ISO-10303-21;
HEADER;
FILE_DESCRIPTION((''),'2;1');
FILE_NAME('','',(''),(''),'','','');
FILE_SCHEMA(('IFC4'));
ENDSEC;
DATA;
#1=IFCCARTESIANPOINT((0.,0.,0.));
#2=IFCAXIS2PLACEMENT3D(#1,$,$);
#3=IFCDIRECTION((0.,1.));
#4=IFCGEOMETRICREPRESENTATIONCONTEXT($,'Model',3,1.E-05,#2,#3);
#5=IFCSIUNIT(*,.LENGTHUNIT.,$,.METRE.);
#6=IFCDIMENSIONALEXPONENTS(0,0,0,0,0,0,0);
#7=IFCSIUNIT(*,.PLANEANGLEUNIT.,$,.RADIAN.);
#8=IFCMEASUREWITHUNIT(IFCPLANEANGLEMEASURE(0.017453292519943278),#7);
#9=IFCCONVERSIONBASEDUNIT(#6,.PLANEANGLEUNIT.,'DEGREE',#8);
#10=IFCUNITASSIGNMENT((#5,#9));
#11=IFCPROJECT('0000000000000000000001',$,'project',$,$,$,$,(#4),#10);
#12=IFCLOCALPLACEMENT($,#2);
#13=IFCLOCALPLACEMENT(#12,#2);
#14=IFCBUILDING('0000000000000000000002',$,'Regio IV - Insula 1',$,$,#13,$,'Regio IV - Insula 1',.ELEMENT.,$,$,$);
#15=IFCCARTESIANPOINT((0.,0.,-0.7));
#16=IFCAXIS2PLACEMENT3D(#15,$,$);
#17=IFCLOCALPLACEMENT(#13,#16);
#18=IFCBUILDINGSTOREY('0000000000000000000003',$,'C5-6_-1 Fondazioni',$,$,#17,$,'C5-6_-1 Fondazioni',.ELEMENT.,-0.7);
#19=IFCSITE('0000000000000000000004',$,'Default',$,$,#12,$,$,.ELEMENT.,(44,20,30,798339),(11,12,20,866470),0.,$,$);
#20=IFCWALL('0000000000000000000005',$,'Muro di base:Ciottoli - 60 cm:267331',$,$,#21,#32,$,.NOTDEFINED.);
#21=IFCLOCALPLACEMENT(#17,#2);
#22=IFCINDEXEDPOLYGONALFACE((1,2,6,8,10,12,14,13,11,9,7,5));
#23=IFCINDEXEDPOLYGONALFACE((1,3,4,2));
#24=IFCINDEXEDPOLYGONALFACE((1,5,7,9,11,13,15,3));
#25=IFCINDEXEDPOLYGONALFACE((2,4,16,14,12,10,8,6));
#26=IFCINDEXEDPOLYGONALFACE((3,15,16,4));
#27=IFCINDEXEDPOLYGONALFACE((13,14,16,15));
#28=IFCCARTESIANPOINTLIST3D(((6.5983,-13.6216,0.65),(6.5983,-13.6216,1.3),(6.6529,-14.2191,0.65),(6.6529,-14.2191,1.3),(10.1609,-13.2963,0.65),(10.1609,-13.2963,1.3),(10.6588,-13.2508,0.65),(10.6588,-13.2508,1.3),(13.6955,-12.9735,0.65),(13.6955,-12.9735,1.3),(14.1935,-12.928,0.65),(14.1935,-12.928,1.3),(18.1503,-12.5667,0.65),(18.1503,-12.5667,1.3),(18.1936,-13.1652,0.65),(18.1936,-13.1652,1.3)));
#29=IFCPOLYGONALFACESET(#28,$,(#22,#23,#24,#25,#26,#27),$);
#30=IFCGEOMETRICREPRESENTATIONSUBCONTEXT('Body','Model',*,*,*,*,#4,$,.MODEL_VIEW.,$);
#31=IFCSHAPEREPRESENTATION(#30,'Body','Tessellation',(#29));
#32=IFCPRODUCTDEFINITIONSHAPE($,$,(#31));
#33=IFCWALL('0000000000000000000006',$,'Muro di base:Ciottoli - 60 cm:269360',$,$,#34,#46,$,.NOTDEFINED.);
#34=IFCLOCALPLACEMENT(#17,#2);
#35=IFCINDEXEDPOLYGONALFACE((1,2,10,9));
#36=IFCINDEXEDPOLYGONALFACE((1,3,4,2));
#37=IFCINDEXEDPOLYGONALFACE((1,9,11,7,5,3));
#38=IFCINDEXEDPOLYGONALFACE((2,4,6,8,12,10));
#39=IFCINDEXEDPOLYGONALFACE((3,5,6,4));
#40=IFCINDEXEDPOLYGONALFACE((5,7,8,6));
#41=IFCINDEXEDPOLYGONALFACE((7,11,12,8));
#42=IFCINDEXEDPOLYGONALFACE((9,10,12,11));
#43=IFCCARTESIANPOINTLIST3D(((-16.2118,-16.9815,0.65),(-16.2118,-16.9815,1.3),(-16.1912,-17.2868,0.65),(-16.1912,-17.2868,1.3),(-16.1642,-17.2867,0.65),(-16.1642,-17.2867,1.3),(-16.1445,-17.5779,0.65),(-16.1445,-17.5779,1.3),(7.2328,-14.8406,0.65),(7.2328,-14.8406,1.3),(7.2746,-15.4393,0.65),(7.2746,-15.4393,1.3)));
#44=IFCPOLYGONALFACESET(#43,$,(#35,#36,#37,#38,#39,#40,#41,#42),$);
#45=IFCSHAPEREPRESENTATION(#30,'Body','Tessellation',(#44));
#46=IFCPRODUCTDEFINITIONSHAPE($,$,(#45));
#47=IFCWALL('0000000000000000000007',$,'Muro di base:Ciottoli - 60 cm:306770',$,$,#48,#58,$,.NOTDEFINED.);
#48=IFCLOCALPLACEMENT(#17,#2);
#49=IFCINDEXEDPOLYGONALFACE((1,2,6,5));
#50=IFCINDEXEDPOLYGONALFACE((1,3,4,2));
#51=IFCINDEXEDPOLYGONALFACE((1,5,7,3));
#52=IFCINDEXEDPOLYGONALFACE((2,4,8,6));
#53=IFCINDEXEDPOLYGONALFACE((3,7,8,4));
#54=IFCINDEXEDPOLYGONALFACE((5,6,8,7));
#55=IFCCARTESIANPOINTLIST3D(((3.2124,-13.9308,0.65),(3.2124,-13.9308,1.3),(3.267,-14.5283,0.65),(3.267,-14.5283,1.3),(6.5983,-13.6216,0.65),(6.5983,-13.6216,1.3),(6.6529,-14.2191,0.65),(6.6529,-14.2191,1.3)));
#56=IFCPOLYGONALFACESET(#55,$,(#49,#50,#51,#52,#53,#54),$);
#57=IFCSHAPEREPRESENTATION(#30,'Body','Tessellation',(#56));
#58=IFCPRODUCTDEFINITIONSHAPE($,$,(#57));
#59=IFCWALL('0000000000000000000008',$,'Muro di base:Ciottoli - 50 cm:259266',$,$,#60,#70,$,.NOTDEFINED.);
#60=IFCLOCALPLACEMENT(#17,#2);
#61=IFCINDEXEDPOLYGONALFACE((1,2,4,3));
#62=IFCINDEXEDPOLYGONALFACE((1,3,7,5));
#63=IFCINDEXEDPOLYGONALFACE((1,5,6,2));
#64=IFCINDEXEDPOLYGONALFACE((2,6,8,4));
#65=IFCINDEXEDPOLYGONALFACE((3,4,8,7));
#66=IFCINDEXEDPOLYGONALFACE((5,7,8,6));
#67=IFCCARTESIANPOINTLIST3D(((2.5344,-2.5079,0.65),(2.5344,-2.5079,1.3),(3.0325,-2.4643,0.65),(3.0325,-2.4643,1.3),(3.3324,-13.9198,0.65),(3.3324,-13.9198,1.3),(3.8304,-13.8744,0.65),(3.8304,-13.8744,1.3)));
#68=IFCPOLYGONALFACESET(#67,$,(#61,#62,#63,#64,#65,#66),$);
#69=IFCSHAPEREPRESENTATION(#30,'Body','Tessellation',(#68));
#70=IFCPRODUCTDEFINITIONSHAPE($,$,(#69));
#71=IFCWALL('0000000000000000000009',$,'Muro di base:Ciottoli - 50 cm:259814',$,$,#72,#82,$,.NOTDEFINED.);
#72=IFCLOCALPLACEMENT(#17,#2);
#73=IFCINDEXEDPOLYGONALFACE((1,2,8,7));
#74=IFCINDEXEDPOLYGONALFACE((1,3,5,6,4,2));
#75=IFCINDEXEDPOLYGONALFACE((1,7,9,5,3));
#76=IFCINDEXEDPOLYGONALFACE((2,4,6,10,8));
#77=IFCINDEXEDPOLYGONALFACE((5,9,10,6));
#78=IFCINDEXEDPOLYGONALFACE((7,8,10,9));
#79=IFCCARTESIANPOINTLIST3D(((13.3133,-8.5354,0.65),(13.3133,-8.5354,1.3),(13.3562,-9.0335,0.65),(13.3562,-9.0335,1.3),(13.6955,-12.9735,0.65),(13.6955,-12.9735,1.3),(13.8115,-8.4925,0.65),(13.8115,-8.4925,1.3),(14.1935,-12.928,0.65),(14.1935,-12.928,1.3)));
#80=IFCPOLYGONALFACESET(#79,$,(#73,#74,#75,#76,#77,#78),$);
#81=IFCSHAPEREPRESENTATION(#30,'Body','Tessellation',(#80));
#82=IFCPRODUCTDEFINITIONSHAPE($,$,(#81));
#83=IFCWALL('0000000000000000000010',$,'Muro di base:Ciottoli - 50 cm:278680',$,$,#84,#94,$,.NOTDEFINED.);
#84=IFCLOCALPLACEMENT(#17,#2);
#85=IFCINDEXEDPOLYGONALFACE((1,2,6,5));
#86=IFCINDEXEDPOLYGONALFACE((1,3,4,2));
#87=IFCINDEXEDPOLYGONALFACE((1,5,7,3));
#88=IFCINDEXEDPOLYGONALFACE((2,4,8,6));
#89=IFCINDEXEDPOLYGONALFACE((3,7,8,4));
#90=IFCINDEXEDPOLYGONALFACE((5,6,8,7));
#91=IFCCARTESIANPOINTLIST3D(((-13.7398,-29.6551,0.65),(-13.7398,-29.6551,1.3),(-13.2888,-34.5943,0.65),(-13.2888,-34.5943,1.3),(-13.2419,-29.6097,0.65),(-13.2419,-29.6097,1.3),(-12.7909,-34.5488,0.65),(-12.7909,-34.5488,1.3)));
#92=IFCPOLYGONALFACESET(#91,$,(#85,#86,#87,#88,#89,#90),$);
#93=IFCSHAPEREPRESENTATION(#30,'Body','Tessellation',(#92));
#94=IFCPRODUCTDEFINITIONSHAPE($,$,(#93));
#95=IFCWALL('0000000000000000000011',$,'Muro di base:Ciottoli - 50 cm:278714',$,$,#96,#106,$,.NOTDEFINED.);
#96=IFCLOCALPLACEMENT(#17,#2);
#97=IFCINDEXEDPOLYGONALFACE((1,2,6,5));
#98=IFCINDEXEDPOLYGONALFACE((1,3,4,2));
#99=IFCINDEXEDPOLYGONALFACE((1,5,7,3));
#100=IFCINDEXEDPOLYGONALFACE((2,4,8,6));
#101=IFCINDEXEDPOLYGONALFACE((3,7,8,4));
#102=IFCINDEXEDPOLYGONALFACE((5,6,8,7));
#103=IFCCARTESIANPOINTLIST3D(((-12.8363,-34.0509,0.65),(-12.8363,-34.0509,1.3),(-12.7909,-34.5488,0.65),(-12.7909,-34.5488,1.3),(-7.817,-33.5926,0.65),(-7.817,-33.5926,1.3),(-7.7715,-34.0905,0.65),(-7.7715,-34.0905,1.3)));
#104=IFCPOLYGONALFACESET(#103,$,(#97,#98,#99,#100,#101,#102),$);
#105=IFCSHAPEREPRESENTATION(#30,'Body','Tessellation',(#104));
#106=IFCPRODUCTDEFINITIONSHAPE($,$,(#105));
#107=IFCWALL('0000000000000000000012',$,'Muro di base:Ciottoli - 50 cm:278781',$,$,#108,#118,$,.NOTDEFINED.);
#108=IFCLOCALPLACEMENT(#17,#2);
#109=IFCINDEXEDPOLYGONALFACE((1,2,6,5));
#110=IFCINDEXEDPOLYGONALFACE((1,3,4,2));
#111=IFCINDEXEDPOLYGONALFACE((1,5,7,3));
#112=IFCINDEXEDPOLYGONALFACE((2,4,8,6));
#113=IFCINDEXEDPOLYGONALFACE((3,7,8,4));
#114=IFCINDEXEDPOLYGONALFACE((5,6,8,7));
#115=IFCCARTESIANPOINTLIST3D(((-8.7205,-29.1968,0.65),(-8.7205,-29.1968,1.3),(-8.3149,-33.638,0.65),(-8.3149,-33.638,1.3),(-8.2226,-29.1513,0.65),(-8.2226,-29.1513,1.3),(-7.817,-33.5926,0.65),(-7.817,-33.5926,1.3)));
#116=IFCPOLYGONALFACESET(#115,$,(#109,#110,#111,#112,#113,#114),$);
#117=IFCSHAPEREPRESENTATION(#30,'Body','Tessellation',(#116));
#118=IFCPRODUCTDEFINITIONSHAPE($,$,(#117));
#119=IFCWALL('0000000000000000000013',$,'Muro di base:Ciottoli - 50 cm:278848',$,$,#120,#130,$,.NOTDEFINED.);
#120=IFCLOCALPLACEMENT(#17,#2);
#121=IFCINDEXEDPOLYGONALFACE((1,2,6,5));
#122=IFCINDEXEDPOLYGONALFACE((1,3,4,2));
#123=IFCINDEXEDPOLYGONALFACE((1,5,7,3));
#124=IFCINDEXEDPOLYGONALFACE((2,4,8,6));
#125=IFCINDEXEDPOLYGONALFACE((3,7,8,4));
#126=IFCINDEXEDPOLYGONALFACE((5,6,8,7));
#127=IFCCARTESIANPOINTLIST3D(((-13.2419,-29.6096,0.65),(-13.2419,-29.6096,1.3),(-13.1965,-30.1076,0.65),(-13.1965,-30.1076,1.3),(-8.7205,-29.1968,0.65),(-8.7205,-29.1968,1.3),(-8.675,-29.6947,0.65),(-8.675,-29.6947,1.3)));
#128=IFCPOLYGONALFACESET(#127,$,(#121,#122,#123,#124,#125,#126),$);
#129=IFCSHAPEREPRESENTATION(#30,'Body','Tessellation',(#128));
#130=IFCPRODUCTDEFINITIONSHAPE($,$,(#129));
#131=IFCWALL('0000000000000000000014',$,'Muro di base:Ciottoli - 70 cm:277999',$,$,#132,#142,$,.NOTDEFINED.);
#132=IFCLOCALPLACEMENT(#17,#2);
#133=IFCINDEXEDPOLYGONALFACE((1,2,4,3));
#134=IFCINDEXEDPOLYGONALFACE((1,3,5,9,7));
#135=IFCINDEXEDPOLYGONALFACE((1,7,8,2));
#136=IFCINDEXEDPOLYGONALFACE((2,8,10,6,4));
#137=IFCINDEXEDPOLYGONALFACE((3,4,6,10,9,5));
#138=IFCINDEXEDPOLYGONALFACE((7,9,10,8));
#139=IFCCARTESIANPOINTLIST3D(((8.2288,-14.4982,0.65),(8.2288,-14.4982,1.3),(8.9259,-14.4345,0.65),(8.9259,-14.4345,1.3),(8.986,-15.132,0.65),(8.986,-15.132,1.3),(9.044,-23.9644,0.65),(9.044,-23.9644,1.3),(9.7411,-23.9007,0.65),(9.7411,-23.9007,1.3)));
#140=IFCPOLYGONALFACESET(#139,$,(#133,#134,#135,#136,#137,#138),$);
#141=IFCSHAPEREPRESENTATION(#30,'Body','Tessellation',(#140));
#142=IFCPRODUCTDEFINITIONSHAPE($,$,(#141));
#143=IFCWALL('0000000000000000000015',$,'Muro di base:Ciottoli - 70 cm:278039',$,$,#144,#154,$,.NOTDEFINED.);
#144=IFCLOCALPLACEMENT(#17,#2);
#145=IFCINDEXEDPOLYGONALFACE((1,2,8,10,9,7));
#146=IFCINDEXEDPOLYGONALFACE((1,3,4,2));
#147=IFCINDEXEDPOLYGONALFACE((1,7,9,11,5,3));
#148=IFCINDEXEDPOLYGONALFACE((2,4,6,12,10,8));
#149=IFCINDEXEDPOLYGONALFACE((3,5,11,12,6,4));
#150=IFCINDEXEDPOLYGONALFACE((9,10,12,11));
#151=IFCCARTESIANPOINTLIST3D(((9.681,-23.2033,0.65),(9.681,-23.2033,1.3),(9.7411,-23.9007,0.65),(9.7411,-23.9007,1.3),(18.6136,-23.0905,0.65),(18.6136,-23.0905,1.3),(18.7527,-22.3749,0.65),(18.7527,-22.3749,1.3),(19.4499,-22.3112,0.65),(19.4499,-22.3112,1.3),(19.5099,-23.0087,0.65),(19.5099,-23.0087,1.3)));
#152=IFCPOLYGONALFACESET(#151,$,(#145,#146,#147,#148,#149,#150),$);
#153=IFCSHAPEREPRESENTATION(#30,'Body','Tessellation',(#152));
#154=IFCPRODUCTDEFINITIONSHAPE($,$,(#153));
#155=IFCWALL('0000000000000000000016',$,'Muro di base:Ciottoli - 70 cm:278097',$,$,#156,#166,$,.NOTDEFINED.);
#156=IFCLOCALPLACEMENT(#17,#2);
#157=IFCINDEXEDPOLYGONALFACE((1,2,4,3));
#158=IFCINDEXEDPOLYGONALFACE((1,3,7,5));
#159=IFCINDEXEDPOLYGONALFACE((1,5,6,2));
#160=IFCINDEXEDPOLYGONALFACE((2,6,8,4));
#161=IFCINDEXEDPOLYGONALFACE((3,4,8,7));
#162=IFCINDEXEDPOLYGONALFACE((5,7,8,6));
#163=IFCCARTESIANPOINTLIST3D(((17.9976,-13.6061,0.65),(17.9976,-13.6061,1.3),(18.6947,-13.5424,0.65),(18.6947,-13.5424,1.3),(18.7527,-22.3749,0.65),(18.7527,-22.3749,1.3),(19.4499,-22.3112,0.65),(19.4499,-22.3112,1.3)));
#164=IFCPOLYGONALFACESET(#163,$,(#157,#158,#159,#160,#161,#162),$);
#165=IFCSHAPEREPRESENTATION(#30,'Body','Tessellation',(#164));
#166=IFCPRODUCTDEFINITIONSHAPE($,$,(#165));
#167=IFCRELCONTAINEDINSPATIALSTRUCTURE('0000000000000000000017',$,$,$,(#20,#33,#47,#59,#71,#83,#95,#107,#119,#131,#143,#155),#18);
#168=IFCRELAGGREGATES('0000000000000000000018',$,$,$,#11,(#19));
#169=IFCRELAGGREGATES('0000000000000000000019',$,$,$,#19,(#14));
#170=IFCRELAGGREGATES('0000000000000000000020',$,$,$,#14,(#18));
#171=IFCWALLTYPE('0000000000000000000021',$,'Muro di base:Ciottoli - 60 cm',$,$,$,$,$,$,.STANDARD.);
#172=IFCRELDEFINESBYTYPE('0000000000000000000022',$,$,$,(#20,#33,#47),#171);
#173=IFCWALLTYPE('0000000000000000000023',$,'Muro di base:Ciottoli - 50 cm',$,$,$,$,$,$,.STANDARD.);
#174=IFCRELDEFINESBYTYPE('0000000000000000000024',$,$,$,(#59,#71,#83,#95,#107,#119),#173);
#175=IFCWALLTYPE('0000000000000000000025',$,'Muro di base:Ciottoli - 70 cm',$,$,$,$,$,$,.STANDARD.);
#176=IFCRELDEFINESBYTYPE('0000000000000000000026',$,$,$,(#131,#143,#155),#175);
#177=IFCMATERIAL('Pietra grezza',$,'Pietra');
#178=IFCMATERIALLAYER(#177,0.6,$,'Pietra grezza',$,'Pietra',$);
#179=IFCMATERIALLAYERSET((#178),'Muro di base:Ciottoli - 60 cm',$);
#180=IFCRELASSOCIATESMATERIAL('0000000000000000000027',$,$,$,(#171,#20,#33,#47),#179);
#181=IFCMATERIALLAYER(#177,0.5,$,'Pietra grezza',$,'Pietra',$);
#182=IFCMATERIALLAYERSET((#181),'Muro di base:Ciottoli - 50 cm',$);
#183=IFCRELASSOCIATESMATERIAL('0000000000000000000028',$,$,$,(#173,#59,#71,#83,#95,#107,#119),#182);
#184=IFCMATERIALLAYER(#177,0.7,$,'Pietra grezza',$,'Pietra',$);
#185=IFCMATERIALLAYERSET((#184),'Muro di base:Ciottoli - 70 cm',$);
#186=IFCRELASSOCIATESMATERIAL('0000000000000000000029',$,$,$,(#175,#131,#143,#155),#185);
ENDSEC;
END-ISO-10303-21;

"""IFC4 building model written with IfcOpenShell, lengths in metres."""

from ifc_helpers import new_model, entity, si_unit, converted_unit, direction, frame, frame_2d, origin, place, context, subcontext, project, spatial, polyline, rectangle, outline, extrude, material, layer, layer_set, layer_usage, type_object, element, save


model = new_model("IFC4")

# Units and contexts
model_context = context("Model", 3, precision=1e-05, world=origin(), true_north=direction((0.0, 1.0)))
body_context = subcontext(model_context, "Body", "Model", "MODEL_VIEW")
ifc_project = project(units=[si_unit("LENGTHUNIT", "METRE"), converted_unit("PLANEANGLEUNIT", "DEGREE", entity("IfcPlaneAngleMeasure", 0.017453292519943278), si_unit("PLANEANGLEUNIT", "RADIAN"), dimensions=[0, 0, 0, 0, 0, 0, 0])], contexts=[model_context])

# Site, building, storey
site_placement = place(None, origin())
site = spatial("IfcSite", under=ifc_project, at=site_placement, Name="Default", CompositionType="ELEMENT", RefLatitude=(44, 20, 30, 798339), RefLongitude=(11, 12, 20, 866470), RefElevation=0.0)
building_placement = place(site_placement, origin())
building = spatial("IfcBuilding", under=site, at=building_placement, Name="Regio IV - Insula 1", LongName="Regio IV - Insula 1", CompositionType="ELEMENT")
storey_placement = place(building_placement, frame((0.0, 0.0, -0.7)))
storey = spatial("IfcBuildingStorey", under=building, at=storey_placement, Name="C5-6_-1 Fondazioni", LongName="C5-6_-1 Fondazioni", CompositionType="ELEMENT", Elevation=-0.7)

# Walls
ifc_material = material(Name="Pietra grezza", Category="Pietra")
ifc_layer_1 = layer(ifc_material, 0.6, Name="Pietra grezza", Category="Pietra")
ifc_layer_set_1 = layer_set([ifc_layer_1], Name="Muro di base:Ciottoli - 60 cm")
ifc_layer_usage_1 = layer_usage(ifc_layer_set_1, "AXIS2", "NEGATIVE", 0.3)
wall_type_1 = type_object("IfcWallType", Name="Muro di base:Ciottoli - 60 cm", PredefinedType="STANDARD", material=ifc_layer_set_1)
wall_1_placement = place(storey_placement, frame((6.6256, -13.9203, 0.65), z_axis=(0.0, 0.0, 1.0), x_axis=(0.995856, 0.090941, 0.0)))
element("IfcWall", 1, at=wall_1_placement, inside=storey, type_object=wall_type_1, material=ifc_layer_usage_1, Name="Muro di base:Ciottoli - 60 cm:267331", PredefinedType="NOTDEFINED", context=body_context, shape_type="SweptSolid", body=[
    extrude(outline(polyline([(11.5887, -0.3), (11.6, 0.3), (7.6267, 0.3), (7.1267, 0.3), (4.0774, 0.3), (3.5774, 0.3), (0.0, 0.3), (0.0, -0.3), (11.5887, -0.3)])), origin(), (0.0, 0.0, 1.0), 0.65),
])
ifc_layer_usage_2 = layer_usage(ifc_layer_set_1, "AXIS2", "NEGATIVE", 0.3)
wall_2_placement = place(storey_placement, frame((-16.1845, -17.2803, 0.65), z_axis=(0.0, 0.0, 1.0), x_axis=(0.995856, 0.090941, 0.0)))
element("IfcWall", 2, at=wall_2_placement, inside=storey, type_object=wall_type_1, material=ifc_layer_usage_2, Name="Muro di base:Ciottoli - 60 cm:269360", PredefinedType="NOTDEFINED", context=body_context, shape_type="SweptSolid", body=[
    extrude(outline(polyline([(23.5294, -0.3), (23.5421, 0.3), (0.0, 0.3), (-0.0072, -0.0059), (0.0197, -0.0082), (0.0128, -0.3), (23.5294, -0.3)])), origin(), (0.0, 0.0, 1.0), 0.65),
])
ifc_layer_usage_3 = layer_usage(ifc_layer_set_1, "AXIS2", "NEGATIVE", 0.3)
wall_3_placement = place(storey_placement, frame((3.2397, -14.2295, 0.65), z_axis=(0.0, 0.0, 1.0), x_axis=(0.995856, 0.090941, 0.0)))
element("IfcWall", 3, at=wall_3_placement, inside=storey, type_object=wall_type_1, material=ifc_layer_usage_3, Name="Muro di base:Ciottoli - 60 cm:306770", PredefinedType="NOTDEFINED", context=body_context, shape_type="SweptSolid", body=[
    extrude(rectangle(XDim=3.4, YDim=0.6, at=frame_2d((1.7, 0.0), x_axis=(-1.0, 0.0))), origin(), (0.0, 0.0, 1.0), 0.65),
])
ifc_layer_2 = layer(ifc_material, 0.5, Name="Pietra grezza", Category="Pietra")
ifc_layer_set_2 = layer_set([ifc_layer_2], Name="Muro di base:Ciottoli - 50 cm")
ifc_layer_usage_4 = layer_usage(ifc_layer_set_2, "AXIS2", "NEGATIVE", 0.25)
wall_type_2 = type_object("IfcWallType", Name="Muro di base:Ciottoli - 50 cm", PredefinedType="STANDARD", material=ifc_layer_set_2)
wall_4_placement = place(storey_placement, frame((3.5818, -13.9024, 0.65), z_axis=(0.0, 0.0, 1.0), x_axis=(-0.069756, 0.997564, 0.0)))
element("IfcWall", 4, at=wall_4_placement, inside=storey, type_object=wall_type_2, material=ifc_layer_usage_4, Name="Muro di base:Ciottoli - 50 cm:259266", PredefinedType="NOTDEFINED", context=body_context, shape_type="SweptSolid", body=[
    extrude(outline(polyline([(11.4486, -0.25), (11.4398, 0.25), (0.0, 0.25), (0.0106, -0.25), (11.4486, -0.25)])), origin(), (0.0, 0.0, 1.0), 0.65),
])
ifc_layer_usage_5 = layer_usage(ifc_layer_set_2, "AXIS2", "NEGATIVE", 0.25)
wall_5_placement = place(storey_placement, frame((13.9446, -12.952, 0.65), z_axis=(0.0, 0.0, 1.0), x_axis=(-0.085801, 0.996312, 0.0)))
element("IfcWall", 5, at=wall_5_placement, inside=storey, type_object=wall_type_2, material=ifc_layer_usage_5, Name="Muro di base:Ciottoli - 50 cm:259814", PredefinedType="NOTDEFINED", context=body_context, shape_type="SweptSolid", body=[
    extrude(outline(polyline([(4.4545, -0.25), (4.4545, 0.25), (3.9545, 0.25), (0.0, 0.25), (0.0026, -0.25), (4.4545, -0.25)])), origin(), (0.0, 0.0, 1.0), 0.65),
])
ifc_layer_usage_6 = layer_usage(ifc_layer_set_2, "AXIS2", "NEGATIVE", 0.25)
wall_6_placement = place(storey_placement, frame((-13.4909, -29.6324, 0.65), z_axis=(0.0, 0.0, 1.0), x_axis=(0.09094, -0.995856, 0.0)))
element("IfcWall", 6, at=wall_6_placement, inside=storey, type_object=wall_type_2, material=ifc_layer_usage_6, Name="Muro di base:Ciottoli - 50 cm:278680", PredefinedType="NOTDEFINED", context=body_context, shape_type="SweptSolid", body=[
    extrude(rectangle(XDim=4.9598, YDim=0.5, at=frame_2d((2.4799, 0.0), x_axis=(-1.0, 0.0))), origin(), (0.0, 0.0, 1.0), 0.65),
])
ifc_layer_usage_7 = layer_usage(ifc_layer_set_2, "AXIS2", "NEGATIVE", 0.25)
wall_7_placement = place(storey_placement, frame((-12.8136, -34.2999, 0.65), z_axis=(0.0, 0.0, 1.0), x_axis=(0.995856, 0.090941, 0.0)))
element("IfcWall", 7, at=wall_7_placement, inside=storey, type_object=wall_type_2, material=ifc_layer_usage_7, Name="Muro di base:Ciottoli - 50 cm:278714", PredefinedType="NOTDEFINED", context=body_context, shape_type="SweptSolid", body=[
    extrude(rectangle(XDim=5.0402, YDim=0.5, at=frame_2d((2.5201, 0.0), x_axis=(-1.0, 0.0))), origin(), (0.0, 0.0, 1.0), 0.65),
])
ifc_layer_usage_8 = layer_usage(ifc_layer_set_2, "AXIS2", "NEGATIVE", 0.25)
wall_8_placement = place(storey_placement, frame((-8.0659, -33.6153, 0.65), z_axis=(0.0, 0.0, 1.0), x_axis=(-0.090941, 0.995856, 0.0)))
element("IfcWall", 8, at=wall_8_placement, inside=storey, type_object=wall_type_2, material=ifc_layer_usage_8, Name="Muro di base:Ciottoli - 50 cm:278781", PredefinedType="NOTDEFINED", context=body_context, shape_type="SweptSolid", body=[
    extrude(rectangle(XDim=4.4598, YDim=0.5, at=frame_2d((2.2299, 0.0), x_axis=(-1.0, 0.0))), origin(), (0.0, 0.0, 1.0), 0.65),
])
ifc_layer_usage_9 = layer_usage(ifc_layer_set_2, "AXIS2", "NEGATIVE", 0.25)
wall_9_placement = place(storey_placement, frame((-8.6978, -29.4457, 0.65), z_axis=(0.0, 0.0, 1.0), x_axis=(-0.995856, -0.090941, 0.0)))
element("IfcWall", 9, at=wall_9_placement, inside=storey, type_object=wall_type_2, material=ifc_layer_usage_9, Name="Muro di base:Ciottoli - 50 cm:278848", PredefinedType="NOTDEFINED", context=body_context, shape_type="SweptSolid", body=[
    extrude(rectangle(XDim=4.5402, YDim=0.5, at=frame_2d((2.2701, 0.0), x_axis=(-1.0, 0.0))), origin(), (0.0, 0.0, 1.0), 0.65),
])
ifc_layer_3 = layer(ifc_material, 0.7, Name="Pietra grezza", Category="Pietra")
ifc_layer_set_3 = layer_set([ifc_layer_3], Name="Muro di base:Ciottoli - 70 cm")
ifc_layer_usage_10 = layer_usage(ifc_layer_set_3, "AXIS2", "NEGATIVE", 0.35)
wall_type_3 = type_object("IfcWallType", Name="Muro di base:Ciottoli - 70 cm", PredefinedType="STANDARD", material=ifc_layer_set_3)
wall_10_placement = place(storey_placement, frame((8.5772, -14.4646, 0.65), z_axis=(0.0, 0.0, 1.0), x_axis=(0.085801, -0.996312, 0.0)))
element("IfcWall", 10, at=wall_10_placement, inside=storey, type_object=wall_type_3, material=ifc_layer_usage_10, Name="Muro di base:Ciottoli - 70 cm:277999", PredefinedType="NOTDEFINED", context=body_context, shape_type="SweptSolid", body=[
    extrude(outline(polyline([(9.5049, -0.35), (9.5012, 0.35), (0.7, 0.35), (0.0, 0.35), (0.0036, -0.35), (9.5049, -0.35)])), origin(), (0.0, 0.0, 1.0), 0.65),
])
ifc_layer_usage_11 = layer_usage(ifc_layer_set_3, "AXIS2", "NEGATIVE", 0.35)
wall_11_placement = place(storey_placement, frame((9.7093, -23.5522, 0.65), z_axis=(0.0, 0.0, 1.0), x_axis=(0.995856, 0.090941, 0.0)))
element("IfcWall", 11, at=wall_11_placement, inside=storey, type_object=wall_type_3, material=ifc_layer_usage_11, Name="Muro di base:Ciottoli - 70 cm:278039", PredefinedType="NOTDEFINED", context=body_context, shape_type="SweptSolid", body=[
    extrude(outline(polyline([(9.8095, -0.35), (9.8131, 0.35), (9.1131, 0.35), (0.0036, 0.35), (0.0, -0.35), (8.9095, -0.35), (9.8095, -0.35)])), origin(), (0.0, 0.0, 1.0), 0.65),
])
ifc_layer_usage_12 = layer_usage(ifc_layer_set_3, "AXIS2", "NEGATIVE", 0.35)
wall_12_placement = place(storey_placement, frame((19.1015, -22.3449, 0.65), z_axis=(0.0, 0.0, 1.0), x_axis=(-0.085801, 0.996312, 0.0)))
element("IfcWall", 12, at=wall_12_placement, inside=storey, type_object=wall_type_3, material=ifc_layer_usage_12, Name="Muro di base:Ciottoli - 70 cm:278097", PredefinedType="NOTDEFINED", context=body_context, shape_type="SweptSolid", body=[
    extrude(outline(polyline([(8.8049, -0.35), (8.8012, 0.35), (0.0, 0.35), (0.0036, -0.35), (8.8049, -0.35)])), origin(), (0.0, 0.0, 1.0), 0.65),
])

save(model, "model.ifc")
